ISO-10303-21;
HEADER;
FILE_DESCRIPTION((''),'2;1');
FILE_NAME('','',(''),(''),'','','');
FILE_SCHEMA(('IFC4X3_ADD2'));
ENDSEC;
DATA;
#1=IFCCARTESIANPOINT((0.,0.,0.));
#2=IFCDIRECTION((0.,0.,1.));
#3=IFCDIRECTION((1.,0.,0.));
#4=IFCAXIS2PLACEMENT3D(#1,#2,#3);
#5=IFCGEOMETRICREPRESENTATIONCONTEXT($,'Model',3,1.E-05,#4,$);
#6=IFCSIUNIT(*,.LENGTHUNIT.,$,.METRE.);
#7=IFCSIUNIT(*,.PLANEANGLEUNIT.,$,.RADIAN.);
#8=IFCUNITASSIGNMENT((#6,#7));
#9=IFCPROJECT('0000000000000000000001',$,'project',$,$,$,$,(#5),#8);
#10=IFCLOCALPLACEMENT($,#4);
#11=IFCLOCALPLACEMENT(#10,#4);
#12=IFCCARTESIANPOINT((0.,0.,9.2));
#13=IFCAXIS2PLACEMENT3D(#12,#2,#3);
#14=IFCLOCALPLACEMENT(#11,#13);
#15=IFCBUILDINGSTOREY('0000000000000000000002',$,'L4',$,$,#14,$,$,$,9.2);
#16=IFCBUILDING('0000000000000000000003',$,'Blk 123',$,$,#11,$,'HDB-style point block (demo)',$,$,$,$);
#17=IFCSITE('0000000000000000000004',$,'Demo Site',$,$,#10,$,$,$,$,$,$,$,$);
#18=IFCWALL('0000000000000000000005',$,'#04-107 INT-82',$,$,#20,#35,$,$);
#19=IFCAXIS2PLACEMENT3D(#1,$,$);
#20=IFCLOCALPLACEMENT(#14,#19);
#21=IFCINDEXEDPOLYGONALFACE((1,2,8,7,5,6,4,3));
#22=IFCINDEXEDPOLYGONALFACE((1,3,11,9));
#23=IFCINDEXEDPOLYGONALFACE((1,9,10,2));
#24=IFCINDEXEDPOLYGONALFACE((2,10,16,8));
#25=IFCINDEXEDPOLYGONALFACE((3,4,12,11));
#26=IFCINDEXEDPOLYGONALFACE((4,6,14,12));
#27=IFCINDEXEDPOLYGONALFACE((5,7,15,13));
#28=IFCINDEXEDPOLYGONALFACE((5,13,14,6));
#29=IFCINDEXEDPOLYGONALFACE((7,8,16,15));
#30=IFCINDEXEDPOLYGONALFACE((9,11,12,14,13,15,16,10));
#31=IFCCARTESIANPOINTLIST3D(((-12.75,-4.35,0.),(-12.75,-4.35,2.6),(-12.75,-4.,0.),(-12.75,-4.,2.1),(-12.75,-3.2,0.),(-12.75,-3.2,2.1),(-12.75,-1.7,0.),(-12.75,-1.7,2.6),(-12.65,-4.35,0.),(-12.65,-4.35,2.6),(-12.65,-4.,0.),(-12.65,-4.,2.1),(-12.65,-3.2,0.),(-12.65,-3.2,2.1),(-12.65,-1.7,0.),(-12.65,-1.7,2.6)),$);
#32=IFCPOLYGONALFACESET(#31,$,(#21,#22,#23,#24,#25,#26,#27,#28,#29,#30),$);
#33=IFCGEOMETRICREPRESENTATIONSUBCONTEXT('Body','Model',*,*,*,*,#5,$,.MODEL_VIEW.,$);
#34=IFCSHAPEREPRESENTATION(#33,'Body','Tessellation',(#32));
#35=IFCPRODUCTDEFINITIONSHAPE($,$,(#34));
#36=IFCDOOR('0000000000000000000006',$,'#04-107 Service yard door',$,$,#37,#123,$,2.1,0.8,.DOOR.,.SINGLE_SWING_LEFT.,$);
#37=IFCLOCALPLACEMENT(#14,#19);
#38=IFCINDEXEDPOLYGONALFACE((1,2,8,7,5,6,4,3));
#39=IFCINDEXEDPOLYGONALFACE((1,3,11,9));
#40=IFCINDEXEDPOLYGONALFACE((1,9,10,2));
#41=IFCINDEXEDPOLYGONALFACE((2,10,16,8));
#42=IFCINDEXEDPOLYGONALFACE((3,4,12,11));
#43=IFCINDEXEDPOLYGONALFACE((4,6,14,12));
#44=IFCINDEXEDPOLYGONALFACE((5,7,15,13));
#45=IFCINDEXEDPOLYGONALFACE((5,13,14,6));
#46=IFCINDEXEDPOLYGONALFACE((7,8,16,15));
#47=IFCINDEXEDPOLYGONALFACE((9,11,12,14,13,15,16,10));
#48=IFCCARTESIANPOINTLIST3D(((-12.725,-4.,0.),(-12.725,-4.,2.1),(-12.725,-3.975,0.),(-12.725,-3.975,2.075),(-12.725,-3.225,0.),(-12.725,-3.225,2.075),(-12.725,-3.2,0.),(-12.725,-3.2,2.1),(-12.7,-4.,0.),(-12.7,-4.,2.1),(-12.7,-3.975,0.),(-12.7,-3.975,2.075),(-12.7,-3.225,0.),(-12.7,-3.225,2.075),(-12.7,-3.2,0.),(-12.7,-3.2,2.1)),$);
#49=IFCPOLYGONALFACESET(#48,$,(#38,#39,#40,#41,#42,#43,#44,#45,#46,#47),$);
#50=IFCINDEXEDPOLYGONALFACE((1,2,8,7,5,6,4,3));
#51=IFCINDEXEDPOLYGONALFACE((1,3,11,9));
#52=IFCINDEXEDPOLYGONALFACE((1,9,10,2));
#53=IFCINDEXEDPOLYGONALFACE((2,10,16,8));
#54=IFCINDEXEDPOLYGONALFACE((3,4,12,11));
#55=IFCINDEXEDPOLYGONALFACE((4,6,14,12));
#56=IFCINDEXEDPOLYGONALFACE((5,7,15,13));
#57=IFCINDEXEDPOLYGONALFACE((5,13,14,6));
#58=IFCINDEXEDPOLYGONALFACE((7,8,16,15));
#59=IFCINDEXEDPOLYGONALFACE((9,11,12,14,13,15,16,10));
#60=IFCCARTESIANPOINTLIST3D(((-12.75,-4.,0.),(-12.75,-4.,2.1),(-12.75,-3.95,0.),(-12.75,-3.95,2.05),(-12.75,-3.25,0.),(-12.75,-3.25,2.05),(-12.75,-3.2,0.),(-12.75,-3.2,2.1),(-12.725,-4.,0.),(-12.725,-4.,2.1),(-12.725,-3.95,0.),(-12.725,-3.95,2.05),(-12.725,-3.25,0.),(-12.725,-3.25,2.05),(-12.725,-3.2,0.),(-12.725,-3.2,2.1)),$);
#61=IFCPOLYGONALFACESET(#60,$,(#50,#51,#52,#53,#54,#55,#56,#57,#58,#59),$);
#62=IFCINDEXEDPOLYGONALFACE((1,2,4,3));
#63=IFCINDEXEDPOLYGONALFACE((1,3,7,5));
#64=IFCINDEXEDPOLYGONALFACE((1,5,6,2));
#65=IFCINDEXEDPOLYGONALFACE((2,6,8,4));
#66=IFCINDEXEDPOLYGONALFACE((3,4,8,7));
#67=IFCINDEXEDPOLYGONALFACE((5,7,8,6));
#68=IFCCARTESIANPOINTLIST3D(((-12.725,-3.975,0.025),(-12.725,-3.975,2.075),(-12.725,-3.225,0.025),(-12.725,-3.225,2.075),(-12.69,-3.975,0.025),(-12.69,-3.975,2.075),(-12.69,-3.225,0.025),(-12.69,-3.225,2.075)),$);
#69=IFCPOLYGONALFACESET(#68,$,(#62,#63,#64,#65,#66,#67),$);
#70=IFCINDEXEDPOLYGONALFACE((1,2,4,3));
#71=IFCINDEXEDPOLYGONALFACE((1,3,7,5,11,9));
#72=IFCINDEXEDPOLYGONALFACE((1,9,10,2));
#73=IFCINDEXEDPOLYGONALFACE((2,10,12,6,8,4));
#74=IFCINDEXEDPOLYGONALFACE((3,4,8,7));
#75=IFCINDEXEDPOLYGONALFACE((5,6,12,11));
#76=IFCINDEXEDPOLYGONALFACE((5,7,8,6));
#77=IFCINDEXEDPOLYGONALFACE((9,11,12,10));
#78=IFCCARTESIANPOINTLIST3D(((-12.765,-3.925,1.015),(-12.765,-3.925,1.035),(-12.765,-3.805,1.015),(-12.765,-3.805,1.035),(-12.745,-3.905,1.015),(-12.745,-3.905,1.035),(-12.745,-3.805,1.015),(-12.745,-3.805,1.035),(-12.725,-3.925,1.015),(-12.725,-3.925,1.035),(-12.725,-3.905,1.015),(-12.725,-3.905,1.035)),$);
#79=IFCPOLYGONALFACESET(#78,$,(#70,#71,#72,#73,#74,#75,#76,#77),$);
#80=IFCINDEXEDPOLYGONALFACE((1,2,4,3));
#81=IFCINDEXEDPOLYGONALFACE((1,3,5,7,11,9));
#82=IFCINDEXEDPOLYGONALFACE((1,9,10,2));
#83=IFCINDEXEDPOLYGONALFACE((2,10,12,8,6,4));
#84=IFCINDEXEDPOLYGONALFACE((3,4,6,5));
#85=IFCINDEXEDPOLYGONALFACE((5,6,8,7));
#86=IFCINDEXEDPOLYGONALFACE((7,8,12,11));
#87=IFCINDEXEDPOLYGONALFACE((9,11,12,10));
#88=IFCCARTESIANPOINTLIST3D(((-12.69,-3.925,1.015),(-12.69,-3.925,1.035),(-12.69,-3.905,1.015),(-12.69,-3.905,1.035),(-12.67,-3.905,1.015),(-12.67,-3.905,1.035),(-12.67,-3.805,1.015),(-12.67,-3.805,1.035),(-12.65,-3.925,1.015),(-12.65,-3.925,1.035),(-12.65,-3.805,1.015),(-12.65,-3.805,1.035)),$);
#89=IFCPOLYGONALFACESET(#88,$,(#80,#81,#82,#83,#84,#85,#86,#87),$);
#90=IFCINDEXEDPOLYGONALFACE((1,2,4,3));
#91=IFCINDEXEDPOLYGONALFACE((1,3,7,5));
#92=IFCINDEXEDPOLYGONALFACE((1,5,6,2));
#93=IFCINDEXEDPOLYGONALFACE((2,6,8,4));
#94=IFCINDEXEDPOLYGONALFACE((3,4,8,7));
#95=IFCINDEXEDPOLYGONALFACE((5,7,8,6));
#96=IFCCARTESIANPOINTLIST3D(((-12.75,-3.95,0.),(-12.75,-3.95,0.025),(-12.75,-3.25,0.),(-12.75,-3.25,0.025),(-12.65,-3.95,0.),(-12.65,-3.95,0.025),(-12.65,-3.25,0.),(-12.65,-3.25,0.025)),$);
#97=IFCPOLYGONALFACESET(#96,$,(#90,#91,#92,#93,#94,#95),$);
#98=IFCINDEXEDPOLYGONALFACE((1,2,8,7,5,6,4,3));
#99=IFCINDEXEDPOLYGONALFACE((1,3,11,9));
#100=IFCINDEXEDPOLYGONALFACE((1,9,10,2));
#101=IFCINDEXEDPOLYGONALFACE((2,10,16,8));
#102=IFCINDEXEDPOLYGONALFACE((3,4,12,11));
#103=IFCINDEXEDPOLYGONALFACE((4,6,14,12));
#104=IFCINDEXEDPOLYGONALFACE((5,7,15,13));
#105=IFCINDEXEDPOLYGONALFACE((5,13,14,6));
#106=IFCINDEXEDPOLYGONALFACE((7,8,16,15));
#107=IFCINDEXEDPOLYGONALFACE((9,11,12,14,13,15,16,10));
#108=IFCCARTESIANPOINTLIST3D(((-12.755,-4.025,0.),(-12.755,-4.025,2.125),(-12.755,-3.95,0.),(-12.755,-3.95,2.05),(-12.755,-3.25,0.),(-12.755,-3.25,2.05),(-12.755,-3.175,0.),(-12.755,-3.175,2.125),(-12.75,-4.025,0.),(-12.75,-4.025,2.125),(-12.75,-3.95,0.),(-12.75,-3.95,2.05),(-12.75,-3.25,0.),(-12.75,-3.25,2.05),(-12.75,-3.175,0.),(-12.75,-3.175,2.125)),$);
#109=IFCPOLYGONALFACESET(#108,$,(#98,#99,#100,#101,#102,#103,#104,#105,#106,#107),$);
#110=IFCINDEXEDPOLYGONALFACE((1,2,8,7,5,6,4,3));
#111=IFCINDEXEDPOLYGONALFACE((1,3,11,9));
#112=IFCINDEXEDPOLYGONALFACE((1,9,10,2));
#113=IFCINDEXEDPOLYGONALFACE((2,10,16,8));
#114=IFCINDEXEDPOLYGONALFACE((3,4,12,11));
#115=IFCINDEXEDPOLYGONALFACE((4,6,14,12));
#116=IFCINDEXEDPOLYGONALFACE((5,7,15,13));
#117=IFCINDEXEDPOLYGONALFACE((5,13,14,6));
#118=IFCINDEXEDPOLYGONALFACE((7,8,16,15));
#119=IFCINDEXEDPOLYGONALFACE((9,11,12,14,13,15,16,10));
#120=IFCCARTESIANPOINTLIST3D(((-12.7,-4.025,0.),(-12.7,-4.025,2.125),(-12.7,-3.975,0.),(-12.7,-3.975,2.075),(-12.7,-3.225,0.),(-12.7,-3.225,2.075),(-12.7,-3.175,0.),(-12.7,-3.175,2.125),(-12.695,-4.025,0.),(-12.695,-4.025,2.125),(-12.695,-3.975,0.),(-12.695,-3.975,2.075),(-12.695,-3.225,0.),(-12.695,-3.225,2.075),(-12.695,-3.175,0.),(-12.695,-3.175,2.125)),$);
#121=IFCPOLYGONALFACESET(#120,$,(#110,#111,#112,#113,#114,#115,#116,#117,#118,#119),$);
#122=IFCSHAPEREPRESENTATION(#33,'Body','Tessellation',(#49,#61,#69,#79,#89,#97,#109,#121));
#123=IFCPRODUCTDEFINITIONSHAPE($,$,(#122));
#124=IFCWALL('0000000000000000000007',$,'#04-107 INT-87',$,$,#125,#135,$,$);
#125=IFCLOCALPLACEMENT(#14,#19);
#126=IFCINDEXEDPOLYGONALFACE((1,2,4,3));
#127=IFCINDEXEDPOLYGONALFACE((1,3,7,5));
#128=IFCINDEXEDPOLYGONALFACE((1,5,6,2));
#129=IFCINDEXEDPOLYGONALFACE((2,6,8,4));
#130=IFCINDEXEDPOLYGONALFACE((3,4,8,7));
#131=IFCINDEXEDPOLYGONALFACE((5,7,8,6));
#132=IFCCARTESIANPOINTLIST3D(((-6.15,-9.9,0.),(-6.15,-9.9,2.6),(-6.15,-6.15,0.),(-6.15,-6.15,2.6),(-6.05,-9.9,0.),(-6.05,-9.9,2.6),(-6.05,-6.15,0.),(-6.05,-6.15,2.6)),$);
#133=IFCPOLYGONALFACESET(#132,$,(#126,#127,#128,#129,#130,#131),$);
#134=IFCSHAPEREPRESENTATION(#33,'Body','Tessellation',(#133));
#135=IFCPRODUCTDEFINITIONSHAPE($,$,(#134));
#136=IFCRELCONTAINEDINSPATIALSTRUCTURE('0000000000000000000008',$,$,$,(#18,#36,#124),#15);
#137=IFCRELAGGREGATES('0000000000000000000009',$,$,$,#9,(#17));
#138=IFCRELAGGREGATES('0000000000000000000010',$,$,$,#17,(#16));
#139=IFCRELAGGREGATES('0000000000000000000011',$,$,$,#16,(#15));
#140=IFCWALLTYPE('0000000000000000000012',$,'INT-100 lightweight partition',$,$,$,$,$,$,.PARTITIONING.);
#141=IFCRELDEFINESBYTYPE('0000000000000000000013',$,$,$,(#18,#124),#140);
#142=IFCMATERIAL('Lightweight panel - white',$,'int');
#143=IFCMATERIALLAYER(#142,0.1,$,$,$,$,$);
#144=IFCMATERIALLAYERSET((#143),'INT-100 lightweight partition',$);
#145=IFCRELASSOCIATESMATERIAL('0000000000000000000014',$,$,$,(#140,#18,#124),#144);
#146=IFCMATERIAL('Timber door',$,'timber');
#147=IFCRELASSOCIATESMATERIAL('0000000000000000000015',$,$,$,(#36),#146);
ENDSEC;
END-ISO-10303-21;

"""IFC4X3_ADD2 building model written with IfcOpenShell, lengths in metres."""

from ifc_helpers import new_model, si_unit, frame, origin_with_axes, place, context, subcontext, project, spatial, line, indexed_curve, outline, extrude, material, layer, layer_set, layer_usage, type_object, element, fill, save


model = new_model("IFC4X3_ADD2")

# Units and contexts
model_context = context("Model", 3, precision=1e-05, world=origin_with_axes())
body_context = subcontext(model_context, "Body", "Model", "MODEL_VIEW")
ifc_project = project(units=[si_unit("LENGTHUNIT", "METRE"), si_unit("PLANEANGLEUNIT", "RADIAN")], contexts=[model_context])

# Site, building, storey
site_placement = place(None, origin_with_axes())
site = spatial("IfcSite", under=ifc_project, at=site_placement, Name="Demo Site")
building_placement = place(site_placement, origin_with_axes())
building = spatial("IfcBuilding", under=site, at=building_placement, Name="Blk 123", LongName="HDB-style point block (demo)")
storey_placement = place(building_placement, frame((0.0, 0.0, 9.2), z_axis=(0.0, 0.0, 1.0), x_axis=(1.0, 0.0, 0.0)))
storey = spatial("IfcBuildingStorey", under=building, at=storey_placement, Name="L4", Elevation=9.2)

# Shared definitions
ifc_material_1 = material(Name="Lightweight panel - white", Category="int")
ifc_layer_1 = layer(ifc_material_1, 0.1)
ifc_layer_set_1 = layer_set([ifc_layer_1], Name="INT-100 lightweight partition")
ifc_layer_usage_1 = layer_usage(ifc_layer_set_1, "AXIS2", "POSITIVE", -0.05)
wall_type_1 = type_object("IfcWallType", Name="INT-100 lightweight partition", PredefinedType="PARTITIONING", material=ifc_layer_set_1)

# Wall, opening, door
ifc_material_2 = material(Name="Timber door", Category="timber")
wall_1_placement = place(storey_placement, frame((-12.7, -1.7, 0.0), z_axis=(0.0, 0.0, 1.0), x_axis=(0.0, -1.0, 0.0)))
wall_1 = element("IfcWall", 1, at=wall_1_placement, inside=storey, type_object=wall_type_1, material=ifc_layer_usage_1, Name="#04-107 INT-82", context=body_context, shape_type="SweptSolid", body=[
    extrude(outline(indexed_curve([(0.0, 0.0), (0.0, 0.1), (2.65, 0.1), (2.65, 0.0), (0.0, 0.0)], self_intersect=False)), frame((0.0, -0.05, 0.0), z_axis=(0.0, 0.0, 1.0), x_axis=(1.0, 0.0, 0.0)), (0.0, 0.0, 1.0), 2.6),
])
opening_1_placement = place(wall_1_placement, frame((1.5, -0.15, 0.0), z_axis=(0.0, 0.0, 1.0), x_axis=(1.0, 0.0, 0.0)))
opening_1 = element("IfcOpeningElement", 2, at=opening_1_placement, cuts=wall_1, context=body_context, shape_type="SweptSolid", body=[
    extrude(outline(indexed_curve([(0.0, 0.0), (0.0, 0.3), (0.8, 0.3), (0.8, 0.0), (0.0, 0.0)], self_intersect=False)), origin_with_axes(), (0.0, 0.0, 1.0), 2.1),
])
door_1_placement = place(opening_1_placement, frame((0.0, 0.1, 0.0), z_axis=(0.0, 0.0, 1.0), x_axis=(1.0, 0.0, 0.0)))
door_1 = element("IfcDoor", 3, at=door_1_placement, inside=storey, material=ifc_material_2, Name="#04-107 Service yard door", OperationType="SINGLE_SWING_LEFT", OverallHeight=2.1, OverallWidth=0.8, PredefinedType="DOOR", context=body_context, shape_type="SweptSolid", body=[
    extrude(outline(indexed_curve([(0.0, 0.0), (0.0, 2.1), (0.8, 2.1), (0.8, 0.0), (0.775, 0.0), (0.775, 2.075), (0.025, 2.075), (0.025, 0.0)], segments=[line(1, 2, 3, 4, 5, 6, 7, 8, 1)])), frame((0.0, 0.025, 0.0), z_axis=(0.0, -1.0, 0.0), x_axis=(1.0, 0.0, 0.0)), (0.0, 0.0, -1.0), 0.025),
    extrude(outline(indexed_curve([(0.0, 0.0), (0.0, 2.1), (0.8, 2.1), (0.8, 0.0), (0.75, 0.0), (0.75, 2.05), (0.05, 2.05), (0.05, 0.0)], segments=[line(1, 2, 3, 4, 5, 6, 7, 8, 1)])), frame((0.0, 0.0, 0.0), z_axis=(0.0, -1.0, 0.0), x_axis=(1.0, 0.0, 0.0)), (0.0, 0.0, -1.0), 0.025),
    extrude(outline(indexed_curve([(0.0, 0.0), (0.75, 0.0), (0.75, 0.035), (0.0, 0.035)], segments=[line(1, 2, 3, 4, 1)])), frame((0.025, 0.025, 0.025), z_axis=(0.0, 0.0, 1.0), x_axis=(1.0, 0.0, 0.0)), (0.0, 0.0, 1.0), 2.05),
    extrude(outline(indexed_curve([(0.0, 0.0), (0.0, -0.04), (-0.12, -0.04), (-0.12, -0.02), (-0.02, -0.02), (-0.02, 0.0)], segments=[line(1, 2, 3, 4, 5, 6, 1)])), frame((0.725, 0.025, 1.015), z_axis=(0.0, 0.0, 1.0), x_axis=(1.0, 0.0, 0.0)), (0.0, 0.0, 1.0), 0.02),
    extrude(outline(indexed_curve([(0.0, 0.0), (0.0, 0.04), (-0.12, 0.04), (-0.12, 0.02), (-0.02, 0.02), (-0.02, 0.0)], segments=[line(1, 2, 3, 4, 5, 6, 1)])), frame((0.725, 0.06, 1.015), z_axis=(0.0, 0.0, 1.0), x_axis=(1.0, 0.0, 0.0)), (0.0, 0.0, 1.0), 0.02),
    extrude(outline(indexed_curve([(0.0, 0.0), (0.7, 0.0), (0.7, 0.1), (0.0, 0.1)], segments=[line(1, 2, 3, 4, 1)])), frame((0.05, 0.0, 0.0), z_axis=(0.0, 0.0, 1.0), x_axis=(1.0, 0.0, 0.0)), (0.0, 0.0, 1.0), 0.025),
    extrude(outline(indexed_curve([(0.0, 0.0), (0.0, 2.125), (0.85, 2.125), (0.85, 0.0), (0.775, 0.0), (0.775, 2.05), (0.075, 2.05), (0.075, 0.0)], segments=[line(1, 2, 3, 4, 5, 6, 7, 8, 1)])), frame((-0.025, -0.005, 0.0), z_axis=(0.0, -1.0, 0.0), x_axis=(1.0, 0.0, 0.0)), (0.0, 0.0, -1.0), 0.005),
    extrude(outline(indexed_curve([(0.0, 0.0), (0.0, 2.125), (0.85, 2.125), (0.85, 0.0), (0.8, 0.0), (0.8, 2.075), (0.05, 2.075), (0.05, 0.0)], segments=[line(1, 2, 3, 4, 5, 6, 7, 8, 1)])), frame((-0.025, 0.05, 0.0), z_axis=(0.0, -1.0, 0.0), x_axis=(1.0, 0.0, 0.0)), (0.0, 0.0, -1.0), 0.005),
])
fill(opening_1, door_1)

# Wall
wall_2_placement = place(storey_placement, frame((-6.1, -6.15, 0.0), z_axis=(0.0, 0.0, 1.0), x_axis=(0.0, -1.0, 0.0)))
element("IfcWall", 4, at=wall_2_placement, inside=storey, type_object=wall_type_1, material=ifc_layer_usage_1, Name="#04-107 INT-87", context=body_context, shape_type="SweptSolid", body=[
    extrude(outline(indexed_curve([(0.0, 0.0), (0.0, 0.1), (3.75, 0.1), (3.75, 0.0), (0.0, 0.0)], self_intersect=False)), frame((0.0, -0.05, 0.0), z_axis=(0.0, 0.0, 1.0), x_axis=(1.0, 0.0, 0.0)), (0.0, 0.0, 1.0), 2.6),
])

save(model, "model.ifc")
